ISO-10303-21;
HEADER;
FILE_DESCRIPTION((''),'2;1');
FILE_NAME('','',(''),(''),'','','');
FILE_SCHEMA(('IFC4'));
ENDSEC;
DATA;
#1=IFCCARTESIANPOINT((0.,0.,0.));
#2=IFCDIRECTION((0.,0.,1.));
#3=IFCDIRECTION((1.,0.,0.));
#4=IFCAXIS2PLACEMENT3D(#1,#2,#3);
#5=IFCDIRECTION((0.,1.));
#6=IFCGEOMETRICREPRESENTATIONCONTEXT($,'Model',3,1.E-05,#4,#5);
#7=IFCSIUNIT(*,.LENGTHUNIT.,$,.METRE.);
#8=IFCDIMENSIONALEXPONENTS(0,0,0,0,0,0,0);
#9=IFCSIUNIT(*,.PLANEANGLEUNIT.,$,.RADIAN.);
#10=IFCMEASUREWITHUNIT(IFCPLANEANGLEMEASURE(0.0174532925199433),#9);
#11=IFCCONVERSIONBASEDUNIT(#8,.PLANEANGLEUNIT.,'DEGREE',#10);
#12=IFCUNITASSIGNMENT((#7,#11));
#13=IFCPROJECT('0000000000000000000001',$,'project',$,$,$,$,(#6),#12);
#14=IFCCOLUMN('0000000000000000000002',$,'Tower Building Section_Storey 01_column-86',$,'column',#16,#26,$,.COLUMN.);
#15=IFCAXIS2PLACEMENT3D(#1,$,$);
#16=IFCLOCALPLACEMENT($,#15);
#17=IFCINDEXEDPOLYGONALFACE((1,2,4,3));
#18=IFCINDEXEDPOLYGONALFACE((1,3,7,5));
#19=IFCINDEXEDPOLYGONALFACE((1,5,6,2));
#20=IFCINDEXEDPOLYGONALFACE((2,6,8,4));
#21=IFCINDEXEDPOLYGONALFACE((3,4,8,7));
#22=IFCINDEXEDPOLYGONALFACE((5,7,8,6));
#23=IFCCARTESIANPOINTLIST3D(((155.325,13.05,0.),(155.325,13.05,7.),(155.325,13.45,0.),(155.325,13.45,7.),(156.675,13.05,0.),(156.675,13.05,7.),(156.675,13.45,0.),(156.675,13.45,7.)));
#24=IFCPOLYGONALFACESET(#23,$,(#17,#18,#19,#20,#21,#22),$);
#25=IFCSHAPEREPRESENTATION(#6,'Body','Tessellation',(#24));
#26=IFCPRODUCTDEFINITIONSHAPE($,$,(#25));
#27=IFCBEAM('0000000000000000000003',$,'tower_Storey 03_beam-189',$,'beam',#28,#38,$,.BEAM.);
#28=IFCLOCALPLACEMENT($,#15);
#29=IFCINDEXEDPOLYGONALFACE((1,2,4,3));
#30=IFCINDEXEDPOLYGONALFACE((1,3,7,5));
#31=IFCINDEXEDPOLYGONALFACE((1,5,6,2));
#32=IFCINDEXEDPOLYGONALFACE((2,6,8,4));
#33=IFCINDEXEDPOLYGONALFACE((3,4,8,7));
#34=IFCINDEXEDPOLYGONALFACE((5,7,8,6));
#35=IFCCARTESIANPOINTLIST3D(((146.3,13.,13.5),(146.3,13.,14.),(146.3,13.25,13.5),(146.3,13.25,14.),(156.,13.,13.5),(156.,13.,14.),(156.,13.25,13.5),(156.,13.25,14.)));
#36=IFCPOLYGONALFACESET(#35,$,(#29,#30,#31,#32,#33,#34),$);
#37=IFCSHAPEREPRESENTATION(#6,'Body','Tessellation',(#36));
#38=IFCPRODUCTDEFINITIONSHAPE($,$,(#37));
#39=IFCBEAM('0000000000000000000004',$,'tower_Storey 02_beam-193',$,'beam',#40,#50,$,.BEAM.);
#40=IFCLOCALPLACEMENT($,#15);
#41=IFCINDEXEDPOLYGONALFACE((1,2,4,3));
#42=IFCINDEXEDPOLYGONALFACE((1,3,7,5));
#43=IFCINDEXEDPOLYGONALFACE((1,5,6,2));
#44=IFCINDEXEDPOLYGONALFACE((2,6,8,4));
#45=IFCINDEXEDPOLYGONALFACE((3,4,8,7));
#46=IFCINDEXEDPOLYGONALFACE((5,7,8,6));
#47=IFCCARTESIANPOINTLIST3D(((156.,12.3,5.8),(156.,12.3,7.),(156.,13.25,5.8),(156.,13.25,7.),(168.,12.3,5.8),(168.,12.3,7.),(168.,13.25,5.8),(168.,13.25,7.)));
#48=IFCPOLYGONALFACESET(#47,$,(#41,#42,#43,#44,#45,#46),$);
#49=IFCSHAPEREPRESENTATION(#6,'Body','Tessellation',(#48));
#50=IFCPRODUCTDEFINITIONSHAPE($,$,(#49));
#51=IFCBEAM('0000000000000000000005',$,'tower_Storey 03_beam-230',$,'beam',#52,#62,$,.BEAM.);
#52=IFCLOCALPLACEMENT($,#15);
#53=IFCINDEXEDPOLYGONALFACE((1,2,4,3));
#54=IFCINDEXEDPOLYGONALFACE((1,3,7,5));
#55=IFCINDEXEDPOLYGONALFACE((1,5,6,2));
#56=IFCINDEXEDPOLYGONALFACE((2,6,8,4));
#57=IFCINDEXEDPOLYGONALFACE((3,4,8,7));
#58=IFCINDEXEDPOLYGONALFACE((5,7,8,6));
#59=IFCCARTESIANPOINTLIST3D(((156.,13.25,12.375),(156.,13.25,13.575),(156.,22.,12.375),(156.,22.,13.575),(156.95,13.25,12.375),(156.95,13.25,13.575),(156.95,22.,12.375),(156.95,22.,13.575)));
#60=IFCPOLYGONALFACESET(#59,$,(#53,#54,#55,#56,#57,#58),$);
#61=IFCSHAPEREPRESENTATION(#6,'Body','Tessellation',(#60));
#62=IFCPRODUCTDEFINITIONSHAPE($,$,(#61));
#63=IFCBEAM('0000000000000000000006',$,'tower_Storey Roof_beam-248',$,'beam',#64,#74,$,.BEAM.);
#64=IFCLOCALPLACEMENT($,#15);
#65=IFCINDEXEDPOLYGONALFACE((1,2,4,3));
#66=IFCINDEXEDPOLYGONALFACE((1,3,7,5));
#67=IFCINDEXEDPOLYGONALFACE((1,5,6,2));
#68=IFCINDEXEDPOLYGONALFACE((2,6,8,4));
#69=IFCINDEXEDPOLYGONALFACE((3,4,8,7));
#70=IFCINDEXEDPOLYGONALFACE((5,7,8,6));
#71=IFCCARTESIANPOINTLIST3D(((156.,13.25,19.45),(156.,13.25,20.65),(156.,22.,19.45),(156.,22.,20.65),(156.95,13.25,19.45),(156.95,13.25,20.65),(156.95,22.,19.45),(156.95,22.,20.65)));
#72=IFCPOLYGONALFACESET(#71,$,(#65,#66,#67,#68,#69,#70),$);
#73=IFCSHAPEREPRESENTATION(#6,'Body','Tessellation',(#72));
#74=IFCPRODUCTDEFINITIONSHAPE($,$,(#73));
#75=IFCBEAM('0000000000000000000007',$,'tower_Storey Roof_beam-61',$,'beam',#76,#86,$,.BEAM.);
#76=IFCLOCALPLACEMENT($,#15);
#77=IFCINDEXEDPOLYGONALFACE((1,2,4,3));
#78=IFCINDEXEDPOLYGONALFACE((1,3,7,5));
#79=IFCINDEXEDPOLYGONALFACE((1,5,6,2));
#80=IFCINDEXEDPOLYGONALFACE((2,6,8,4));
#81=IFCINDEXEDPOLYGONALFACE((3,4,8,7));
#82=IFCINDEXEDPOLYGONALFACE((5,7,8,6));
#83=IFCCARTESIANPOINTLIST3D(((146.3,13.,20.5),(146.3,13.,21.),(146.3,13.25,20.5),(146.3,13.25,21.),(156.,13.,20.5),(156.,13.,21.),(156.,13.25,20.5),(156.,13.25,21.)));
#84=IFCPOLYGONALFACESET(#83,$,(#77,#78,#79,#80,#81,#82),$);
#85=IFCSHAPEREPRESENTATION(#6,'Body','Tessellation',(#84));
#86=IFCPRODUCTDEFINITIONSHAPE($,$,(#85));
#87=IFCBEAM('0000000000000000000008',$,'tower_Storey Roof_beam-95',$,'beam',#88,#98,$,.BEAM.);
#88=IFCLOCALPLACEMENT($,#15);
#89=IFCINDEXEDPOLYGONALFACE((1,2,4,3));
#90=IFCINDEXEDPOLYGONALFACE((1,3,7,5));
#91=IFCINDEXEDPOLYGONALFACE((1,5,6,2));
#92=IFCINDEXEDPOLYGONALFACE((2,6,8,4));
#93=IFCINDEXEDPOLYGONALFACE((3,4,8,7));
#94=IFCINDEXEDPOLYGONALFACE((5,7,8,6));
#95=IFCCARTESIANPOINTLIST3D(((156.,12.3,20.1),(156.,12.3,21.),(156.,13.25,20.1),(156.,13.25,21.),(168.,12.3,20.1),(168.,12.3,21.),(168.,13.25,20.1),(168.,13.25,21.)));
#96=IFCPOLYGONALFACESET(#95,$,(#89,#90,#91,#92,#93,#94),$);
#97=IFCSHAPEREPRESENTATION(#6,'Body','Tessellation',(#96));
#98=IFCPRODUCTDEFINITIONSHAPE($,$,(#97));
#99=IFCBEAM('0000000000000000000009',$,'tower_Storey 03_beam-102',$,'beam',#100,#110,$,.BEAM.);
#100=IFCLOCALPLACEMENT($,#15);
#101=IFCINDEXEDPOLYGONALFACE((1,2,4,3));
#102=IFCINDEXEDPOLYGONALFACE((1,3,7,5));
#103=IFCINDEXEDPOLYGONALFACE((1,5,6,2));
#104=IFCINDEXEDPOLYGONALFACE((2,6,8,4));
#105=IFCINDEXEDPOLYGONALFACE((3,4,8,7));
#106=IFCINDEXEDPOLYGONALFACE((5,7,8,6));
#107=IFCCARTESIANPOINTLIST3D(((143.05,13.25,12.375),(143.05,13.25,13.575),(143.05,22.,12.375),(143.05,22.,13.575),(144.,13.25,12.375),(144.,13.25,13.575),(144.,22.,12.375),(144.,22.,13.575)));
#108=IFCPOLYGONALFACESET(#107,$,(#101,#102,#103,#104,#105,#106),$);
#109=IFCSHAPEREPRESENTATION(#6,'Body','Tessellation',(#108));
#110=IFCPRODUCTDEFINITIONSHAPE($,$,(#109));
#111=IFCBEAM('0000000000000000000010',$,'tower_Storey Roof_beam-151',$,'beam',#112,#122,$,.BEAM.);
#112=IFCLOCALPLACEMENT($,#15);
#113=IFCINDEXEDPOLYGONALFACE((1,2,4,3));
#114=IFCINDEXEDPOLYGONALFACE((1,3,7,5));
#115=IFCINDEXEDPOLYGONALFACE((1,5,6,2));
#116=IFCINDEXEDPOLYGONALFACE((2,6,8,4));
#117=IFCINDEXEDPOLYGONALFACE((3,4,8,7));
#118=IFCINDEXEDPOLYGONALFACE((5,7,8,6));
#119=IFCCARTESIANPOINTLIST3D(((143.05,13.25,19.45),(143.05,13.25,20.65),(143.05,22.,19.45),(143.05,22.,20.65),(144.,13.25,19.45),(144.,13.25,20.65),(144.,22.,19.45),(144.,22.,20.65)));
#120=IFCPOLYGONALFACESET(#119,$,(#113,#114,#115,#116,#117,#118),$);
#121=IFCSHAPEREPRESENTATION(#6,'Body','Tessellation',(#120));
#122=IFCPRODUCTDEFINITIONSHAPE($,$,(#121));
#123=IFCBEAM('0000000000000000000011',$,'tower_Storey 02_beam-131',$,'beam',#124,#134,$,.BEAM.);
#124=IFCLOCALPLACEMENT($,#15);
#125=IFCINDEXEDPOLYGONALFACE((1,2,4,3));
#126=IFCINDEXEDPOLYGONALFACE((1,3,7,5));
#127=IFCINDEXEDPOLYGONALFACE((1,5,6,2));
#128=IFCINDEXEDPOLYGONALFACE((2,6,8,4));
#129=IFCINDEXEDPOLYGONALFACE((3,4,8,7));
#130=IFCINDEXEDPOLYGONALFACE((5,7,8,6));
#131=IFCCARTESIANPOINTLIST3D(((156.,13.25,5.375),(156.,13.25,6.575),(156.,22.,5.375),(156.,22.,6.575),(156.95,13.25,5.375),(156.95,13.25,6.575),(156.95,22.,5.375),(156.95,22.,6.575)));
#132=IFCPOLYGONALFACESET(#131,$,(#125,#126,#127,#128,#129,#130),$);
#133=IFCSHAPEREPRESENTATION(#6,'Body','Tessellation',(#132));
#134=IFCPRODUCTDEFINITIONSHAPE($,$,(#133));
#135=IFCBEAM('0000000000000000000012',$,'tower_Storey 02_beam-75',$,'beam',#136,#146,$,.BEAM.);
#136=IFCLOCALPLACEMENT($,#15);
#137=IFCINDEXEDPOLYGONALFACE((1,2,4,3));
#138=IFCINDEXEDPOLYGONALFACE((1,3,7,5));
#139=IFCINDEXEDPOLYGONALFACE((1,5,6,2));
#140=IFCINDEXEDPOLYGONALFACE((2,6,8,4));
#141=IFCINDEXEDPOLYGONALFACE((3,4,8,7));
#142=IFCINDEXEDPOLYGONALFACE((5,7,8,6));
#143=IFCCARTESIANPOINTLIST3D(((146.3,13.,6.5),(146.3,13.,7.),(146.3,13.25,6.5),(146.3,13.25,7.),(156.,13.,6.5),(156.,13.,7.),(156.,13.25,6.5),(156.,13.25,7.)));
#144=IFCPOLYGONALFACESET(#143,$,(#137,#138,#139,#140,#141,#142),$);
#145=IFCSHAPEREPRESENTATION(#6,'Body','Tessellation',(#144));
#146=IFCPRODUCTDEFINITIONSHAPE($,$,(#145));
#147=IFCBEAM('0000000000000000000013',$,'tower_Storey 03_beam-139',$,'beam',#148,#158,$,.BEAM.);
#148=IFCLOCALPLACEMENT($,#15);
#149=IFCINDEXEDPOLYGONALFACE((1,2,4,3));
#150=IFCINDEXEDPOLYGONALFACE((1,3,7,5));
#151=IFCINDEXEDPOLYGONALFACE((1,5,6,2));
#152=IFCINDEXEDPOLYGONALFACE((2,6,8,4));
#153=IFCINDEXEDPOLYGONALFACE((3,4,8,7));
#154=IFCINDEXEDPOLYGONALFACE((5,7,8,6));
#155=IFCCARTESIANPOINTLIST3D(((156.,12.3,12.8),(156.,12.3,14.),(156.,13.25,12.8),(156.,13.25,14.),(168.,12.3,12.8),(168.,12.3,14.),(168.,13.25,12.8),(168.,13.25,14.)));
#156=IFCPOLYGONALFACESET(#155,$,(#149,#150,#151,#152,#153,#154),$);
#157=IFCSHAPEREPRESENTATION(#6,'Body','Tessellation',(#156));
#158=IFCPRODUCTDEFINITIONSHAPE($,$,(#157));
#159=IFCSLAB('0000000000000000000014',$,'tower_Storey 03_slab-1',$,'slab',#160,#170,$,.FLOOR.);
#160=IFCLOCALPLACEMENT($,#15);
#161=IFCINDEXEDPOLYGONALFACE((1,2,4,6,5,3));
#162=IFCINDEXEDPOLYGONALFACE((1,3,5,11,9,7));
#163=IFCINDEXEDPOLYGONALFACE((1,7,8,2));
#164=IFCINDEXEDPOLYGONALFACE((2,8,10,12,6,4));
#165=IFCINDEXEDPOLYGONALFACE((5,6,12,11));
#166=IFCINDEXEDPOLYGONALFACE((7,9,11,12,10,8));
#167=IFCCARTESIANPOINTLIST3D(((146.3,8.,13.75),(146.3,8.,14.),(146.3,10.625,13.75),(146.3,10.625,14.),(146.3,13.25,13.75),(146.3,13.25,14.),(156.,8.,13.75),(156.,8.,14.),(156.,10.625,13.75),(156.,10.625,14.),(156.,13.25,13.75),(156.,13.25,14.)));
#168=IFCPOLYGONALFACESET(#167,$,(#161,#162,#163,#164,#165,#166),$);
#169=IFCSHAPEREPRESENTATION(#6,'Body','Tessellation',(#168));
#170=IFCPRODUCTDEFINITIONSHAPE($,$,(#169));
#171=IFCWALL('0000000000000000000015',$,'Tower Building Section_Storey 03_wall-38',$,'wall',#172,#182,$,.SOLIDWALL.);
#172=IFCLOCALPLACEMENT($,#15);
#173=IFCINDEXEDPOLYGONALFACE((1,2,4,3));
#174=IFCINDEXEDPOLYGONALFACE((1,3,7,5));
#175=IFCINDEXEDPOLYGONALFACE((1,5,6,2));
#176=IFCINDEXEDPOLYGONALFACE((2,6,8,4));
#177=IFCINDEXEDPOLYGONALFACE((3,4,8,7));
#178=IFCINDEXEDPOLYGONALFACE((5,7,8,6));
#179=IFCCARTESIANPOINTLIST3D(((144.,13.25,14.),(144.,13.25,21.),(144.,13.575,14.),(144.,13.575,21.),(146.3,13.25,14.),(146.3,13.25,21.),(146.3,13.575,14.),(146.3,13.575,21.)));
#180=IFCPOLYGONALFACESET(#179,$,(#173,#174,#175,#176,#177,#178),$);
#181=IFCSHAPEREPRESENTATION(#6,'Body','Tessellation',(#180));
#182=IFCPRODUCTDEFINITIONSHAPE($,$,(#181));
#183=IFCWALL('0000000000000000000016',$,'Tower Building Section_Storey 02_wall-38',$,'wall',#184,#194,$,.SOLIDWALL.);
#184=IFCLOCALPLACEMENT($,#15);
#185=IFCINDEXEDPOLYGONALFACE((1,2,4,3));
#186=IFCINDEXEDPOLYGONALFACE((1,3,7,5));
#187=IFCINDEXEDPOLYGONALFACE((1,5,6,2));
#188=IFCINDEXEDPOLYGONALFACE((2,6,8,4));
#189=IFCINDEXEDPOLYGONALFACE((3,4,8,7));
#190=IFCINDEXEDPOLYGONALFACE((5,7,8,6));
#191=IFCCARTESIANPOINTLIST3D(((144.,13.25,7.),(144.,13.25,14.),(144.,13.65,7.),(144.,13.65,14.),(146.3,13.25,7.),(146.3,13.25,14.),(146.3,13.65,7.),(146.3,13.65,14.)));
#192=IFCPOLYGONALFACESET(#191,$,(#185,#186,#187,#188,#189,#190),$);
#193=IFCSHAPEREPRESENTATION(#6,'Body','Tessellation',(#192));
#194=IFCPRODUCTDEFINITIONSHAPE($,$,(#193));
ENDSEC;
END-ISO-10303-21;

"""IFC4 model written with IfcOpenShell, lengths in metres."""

from ifc_helpers import new_model, entity, si_unit, converted_unit, direction, frame, origin_with_axes, place, context, project, polyline, outline, extrude, element, save


model = new_model("IFC4")

# Units and contexts
model_context = context("Model", 3, precision=1e-05, world=origin_with_axes(), true_north=direction((0.0, 1.0)))
ifc_project = project(units=[si_unit("LENGTHUNIT", "METRE"), converted_unit("PLANEANGLEUNIT", "DEGREE", entity("IfcPlaneAngleMeasure", 0.0174532925199433), si_unit("PLANEANGLEUNIT", "RADIAN"), dimensions=[0, 0, 0, 0, 0, 0, 0])], contexts=[model_context])

# Shared definitions
placement_1 = place(None, origin_with_axes())
placement_2 = place(placement_1, origin_with_axes())

# Column
placement_3 = place(placement_1, frame((0.0, 0.0, 7.0), z_axis=(0.0, 0.0, 1.0), x_axis=(1.0, 0.0, 0.0)))
placement_4 = place(placement_1, frame((0.0, 0.0, 14.0), z_axis=(0.0, 0.0, 1.0), x_axis=(1.0, 0.0, 0.0)))
column_1_placement = place(placement_2, frame((156.0, 13.25, 0.0), z_axis=(0.0, 0.0, 1.0), x_axis=(1.0, 0.0, 0.0)))
element("IfcColumn", 1, at=column_1_placement, Name="Tower Building Section_Storey 01_column-86", ObjectType="column", PredefinedType="COLUMN", context=model_context, body=[
    extrude(outline(polyline([(-0.675, -0.2, 0.0), (0.675, -0.2, 0.0), (0.675, 0.2, 0.0), (-0.675, 0.2, 0.0), (-0.675, -0.2, 0.0)])), origin_with_axes(), (0.0, 0.0, 1.0), 7.0),
])

# Beams
beam_1_placement = place(placement_4, frame((146.3, 13.125, -0.25), z_axis=(1.0, 0.0, 0.0), x_axis=(0.0, 1.0, 0.0)))
element("IfcBeam", 2, at=beam_1_placement, Name="tower_Storey 03_beam-189", ObjectType="beam", PredefinedType="BEAM", context=model_context, body=[
    extrude(outline(polyline([(0.125, 0.25, 0.0), (-0.125, 0.25, 0.0), (-0.125, -0.25, 0.0), (0.125, -0.25, 0.0), (0.125, 0.25, 0.0)])), origin_with_axes(), (0.0, 0.0, 1.0), 9.7),
])
beam_2_placement = place(placement_3, frame((156.0, 12.775, -0.6), z_axis=(1.0, 0.0, 0.0), x_axis=(0.0, 1.0, 0.0)))
element("IfcBeam", 3, at=beam_2_placement, Name="tower_Storey 02_beam-193", ObjectType="beam", PredefinedType="BEAM", context=model_context, body=[
    extrude(outline(polyline([(0.475, 0.6, 0.0), (-0.475, 0.6, 0.0), (-0.475, -0.6, 0.0), (0.475, -0.6, 0.0), (0.475, 0.6, 0.0)])), origin_with_axes(), (0.0, 0.0, 1.0), 12.0),
])
beam_3_placement = place(placement_4, frame((156.475, 13.25, -1.025), z_axis=(0.0, 1.0, 0.0), x_axis=(-1.0, 0.0, 0.0)))
element("IfcBeam", 4, at=beam_3_placement, Name="tower_Storey 03_beam-230", ObjectType="beam", PredefinedType="BEAM", context=model_context, body=[
    extrude(outline(polyline([(0.475, 0.6, 0.0), (-0.475, 0.6, 0.0), (-0.475, -0.6, 0.0), (0.475, -0.6, 0.0), (0.475, 0.6, 0.0)])), origin_with_axes(), (0.0, 0.0, 1.0), 8.75),
])
placement_5 = place(placement_1, frame((0.0, 0.0, 21.0), z_axis=(0.0, 0.0, 1.0), x_axis=(1.0, 0.0, 0.0)))
beam_4_placement = place(placement_5, frame((156.475, 13.25, -0.95), z_axis=(0.0, 1.0, 0.0), x_axis=(-1.0, 0.0, 0.0)))
element("IfcBeam", 5, at=beam_4_placement, Name="tower_Storey Roof_beam-248", ObjectType="beam", PredefinedType="BEAM", context=model_context, body=[
    extrude(outline(polyline([(0.475, 0.6, 0.0), (-0.475, 0.6, 0.0), (-0.475, -0.6, 0.0), (0.475, -0.6, 0.0), (0.475, 0.6, 0.0)])), origin_with_axes(), (0.0, 0.0, 1.0), 8.75),
])
beam_5_placement = place(placement_5, frame((146.3, 13.125, -0.25), z_axis=(1.0, 0.0, 0.0), x_axis=(0.0, 1.0, 0.0)))
element("IfcBeam", 6, at=beam_5_placement, Name="tower_Storey Roof_beam-61", ObjectType="beam", PredefinedType="BEAM", context=model_context, body=[
    extrude(outline(polyline([(0.125, 0.25, 0.0), (-0.125, 0.25, 0.0), (-0.125, -0.25, 0.0), (0.125, -0.25, 0.0), (0.125, 0.25, 0.0)])), origin_with_axes(), (0.0, 0.0, 1.0), 9.7),
])
beam_6_placement = place(placement_5, frame((156.0, 12.775, -0.45), z_axis=(1.0, 0.0, 0.0), x_axis=(0.0, 1.0, 0.0)))
element("IfcBeam", 7, at=beam_6_placement, Name="tower_Storey Roof_beam-95", ObjectType="beam", PredefinedType="BEAM", context=model_context, body=[
    extrude(outline(polyline([(0.475, 0.45, 0.0), (-0.475, 0.45, 0.0), (-0.475, -0.45, 0.0), (0.475, -0.45, 0.0), (0.475, 0.45, 0.0)])), origin_with_axes(), (0.0, 0.0, 1.0), 12.0),
])
beam_7_placement = place(placement_4, frame((143.525, 13.25, -1.025), z_axis=(0.0, 1.0, 0.0), x_axis=(-1.0, 0.0, 0.0)))
element("IfcBeam", 8, at=beam_7_placement, Name="tower_Storey 03_beam-102", ObjectType="beam", PredefinedType="BEAM", context=model_context, body=[
    extrude(outline(polyline([(0.475, 0.6, 0.0), (-0.475, 0.6, 0.0), (-0.475, -0.6, 0.0), (0.475, -0.6, 0.0), (0.475, 0.6, 0.0)])), origin_with_axes(), (0.0, 0.0, 1.0), 8.75),
])
beam_8_placement = place(placement_5, frame((143.525, 13.25, -0.95), z_axis=(0.0, 1.0, 0.0), x_axis=(-1.0, 0.0, 0.0)))
element("IfcBeam", 9, at=beam_8_placement, Name="tower_Storey Roof_beam-151", ObjectType="beam", PredefinedType="BEAM", context=model_context, body=[
    extrude(outline(polyline([(0.475, 0.6, 0.0), (-0.475, 0.6, 0.0), (-0.475, -0.6, 0.0), (0.475, -0.6, 0.0), (0.475, 0.6, 0.0)])), origin_with_axes(), (0.0, 0.0, 1.0), 8.75),
])
beam_9_placement = place(placement_3, frame((156.475, 13.25, -1.025), z_axis=(0.0, 1.0, 0.0), x_axis=(-1.0, 0.0, 0.0)))
element("IfcBeam", 10, at=beam_9_placement, Name="tower_Storey 02_beam-131", ObjectType="beam", PredefinedType="BEAM", context=model_context, body=[
    extrude(outline(polyline([(0.475, 0.6, 0.0), (-0.475, 0.6, 0.0), (-0.475, -0.6, 0.0), (0.475, -0.6, 0.0), (0.475, 0.6, 0.0)])), origin_with_axes(), (0.0, 0.0, 1.0), 8.75),
])
beam_10_placement = place(placement_3, frame((146.3, 13.125, -0.25), z_axis=(1.0, 0.0, 0.0), x_axis=(0.0, 1.0, 0.0)))
element("IfcBeam", 11, at=beam_10_placement, Name="tower_Storey 02_beam-75", ObjectType="beam", PredefinedType="BEAM", context=model_context, body=[
    extrude(outline(polyline([(0.125, 0.25, 0.0), (-0.125, 0.25, 0.0), (-0.125, -0.25, 0.0), (0.125, -0.25, 0.0), (0.125, 0.25, 0.0)])), origin_with_axes(), (0.0, 0.0, 1.0), 9.7),
])
beam_11_placement = place(placement_4, frame((156.0, 12.775, -0.6), z_axis=(1.0, 0.0, 0.0), x_axis=(0.0, 1.0, 0.0)))
element("IfcBeam", 12, at=beam_11_placement, Name="tower_Storey 03_beam-139", ObjectType="beam", PredefinedType="BEAM", context=model_context, body=[
    extrude(outline(polyline([(0.475, 0.6, 0.0), (-0.475, 0.6, 0.0), (-0.475, -0.6, 0.0), (0.475, -0.6, 0.0), (0.475, 0.6, 0.0)])), origin_with_axes(), (0.0, 0.0, 1.0), 12.0),
])

# Slab
slab_placement = place(placement_4, frame((151.15, 10.625, -0.25), z_axis=(0.0, 0.0, 1.0), x_axis=(1.0, 0.0, 0.0)))
element("IfcSlab", 13, at=slab_placement, Name="tower_Storey 03_slab-1", ObjectType="slab", PredefinedType="FLOOR", context=model_context, body=[
    extrude(outline(polyline([(-4.85, -2.625, 0.0), (4.85, -2.625, 0.0), (4.85, 0.0, 0.0), (4.85, 2.625, 0.0), (-4.85, 2.625, 0.0), (-4.85, 0.0, 0.0), (-4.85, -2.625, 0.0)])), origin_with_axes(), (0.0, 0.0, 1.0), 0.25),
])

# Walls
wall_1_placement = place(placement_4, frame((145.15, 13.25, 3.5), z_axis=(0.0, 1.0, 0.0), x_axis=(0.0, 0.0, 1.0)))
element("IfcWall", 14, at=wall_1_placement, Name="Tower Building Section_Storey 03_wall-38", ObjectType="wall", PredefinedType="SOLIDWALL", context=model_context, body=[
    extrude(outline(polyline([(-3.5, -1.15, 0.0), (3.5, -1.15, 0.0), (3.5, 1.15, 0.0), (-3.5, 1.15, 0.0), (-3.5, -1.15, 0.0)])), origin_with_axes(), (0.0, 0.0, 1.0), 0.325),
])
wall_2_placement = place(placement_3, frame((145.15, 13.25, 3.5), z_axis=(0.0, 1.0, 0.0), x_axis=(0.0, 0.0, 1.0)))
element("IfcWall", 15, at=wall_2_placement, Name="Tower Building Section_Storey 02_wall-38", ObjectType="wall", PredefinedType="SOLIDWALL", context=model_context, body=[
    extrude(outline(polyline([(-3.5, -1.15, 0.0), (3.5, -1.15, 0.0), (3.5, 1.15, 0.0), (-3.5, 1.15, 0.0), (-3.5, -1.15, 0.0)])), origin_with_axes(), (0.0, 0.0, 1.0), 0.4),
])

save(model, "model.ifc")
